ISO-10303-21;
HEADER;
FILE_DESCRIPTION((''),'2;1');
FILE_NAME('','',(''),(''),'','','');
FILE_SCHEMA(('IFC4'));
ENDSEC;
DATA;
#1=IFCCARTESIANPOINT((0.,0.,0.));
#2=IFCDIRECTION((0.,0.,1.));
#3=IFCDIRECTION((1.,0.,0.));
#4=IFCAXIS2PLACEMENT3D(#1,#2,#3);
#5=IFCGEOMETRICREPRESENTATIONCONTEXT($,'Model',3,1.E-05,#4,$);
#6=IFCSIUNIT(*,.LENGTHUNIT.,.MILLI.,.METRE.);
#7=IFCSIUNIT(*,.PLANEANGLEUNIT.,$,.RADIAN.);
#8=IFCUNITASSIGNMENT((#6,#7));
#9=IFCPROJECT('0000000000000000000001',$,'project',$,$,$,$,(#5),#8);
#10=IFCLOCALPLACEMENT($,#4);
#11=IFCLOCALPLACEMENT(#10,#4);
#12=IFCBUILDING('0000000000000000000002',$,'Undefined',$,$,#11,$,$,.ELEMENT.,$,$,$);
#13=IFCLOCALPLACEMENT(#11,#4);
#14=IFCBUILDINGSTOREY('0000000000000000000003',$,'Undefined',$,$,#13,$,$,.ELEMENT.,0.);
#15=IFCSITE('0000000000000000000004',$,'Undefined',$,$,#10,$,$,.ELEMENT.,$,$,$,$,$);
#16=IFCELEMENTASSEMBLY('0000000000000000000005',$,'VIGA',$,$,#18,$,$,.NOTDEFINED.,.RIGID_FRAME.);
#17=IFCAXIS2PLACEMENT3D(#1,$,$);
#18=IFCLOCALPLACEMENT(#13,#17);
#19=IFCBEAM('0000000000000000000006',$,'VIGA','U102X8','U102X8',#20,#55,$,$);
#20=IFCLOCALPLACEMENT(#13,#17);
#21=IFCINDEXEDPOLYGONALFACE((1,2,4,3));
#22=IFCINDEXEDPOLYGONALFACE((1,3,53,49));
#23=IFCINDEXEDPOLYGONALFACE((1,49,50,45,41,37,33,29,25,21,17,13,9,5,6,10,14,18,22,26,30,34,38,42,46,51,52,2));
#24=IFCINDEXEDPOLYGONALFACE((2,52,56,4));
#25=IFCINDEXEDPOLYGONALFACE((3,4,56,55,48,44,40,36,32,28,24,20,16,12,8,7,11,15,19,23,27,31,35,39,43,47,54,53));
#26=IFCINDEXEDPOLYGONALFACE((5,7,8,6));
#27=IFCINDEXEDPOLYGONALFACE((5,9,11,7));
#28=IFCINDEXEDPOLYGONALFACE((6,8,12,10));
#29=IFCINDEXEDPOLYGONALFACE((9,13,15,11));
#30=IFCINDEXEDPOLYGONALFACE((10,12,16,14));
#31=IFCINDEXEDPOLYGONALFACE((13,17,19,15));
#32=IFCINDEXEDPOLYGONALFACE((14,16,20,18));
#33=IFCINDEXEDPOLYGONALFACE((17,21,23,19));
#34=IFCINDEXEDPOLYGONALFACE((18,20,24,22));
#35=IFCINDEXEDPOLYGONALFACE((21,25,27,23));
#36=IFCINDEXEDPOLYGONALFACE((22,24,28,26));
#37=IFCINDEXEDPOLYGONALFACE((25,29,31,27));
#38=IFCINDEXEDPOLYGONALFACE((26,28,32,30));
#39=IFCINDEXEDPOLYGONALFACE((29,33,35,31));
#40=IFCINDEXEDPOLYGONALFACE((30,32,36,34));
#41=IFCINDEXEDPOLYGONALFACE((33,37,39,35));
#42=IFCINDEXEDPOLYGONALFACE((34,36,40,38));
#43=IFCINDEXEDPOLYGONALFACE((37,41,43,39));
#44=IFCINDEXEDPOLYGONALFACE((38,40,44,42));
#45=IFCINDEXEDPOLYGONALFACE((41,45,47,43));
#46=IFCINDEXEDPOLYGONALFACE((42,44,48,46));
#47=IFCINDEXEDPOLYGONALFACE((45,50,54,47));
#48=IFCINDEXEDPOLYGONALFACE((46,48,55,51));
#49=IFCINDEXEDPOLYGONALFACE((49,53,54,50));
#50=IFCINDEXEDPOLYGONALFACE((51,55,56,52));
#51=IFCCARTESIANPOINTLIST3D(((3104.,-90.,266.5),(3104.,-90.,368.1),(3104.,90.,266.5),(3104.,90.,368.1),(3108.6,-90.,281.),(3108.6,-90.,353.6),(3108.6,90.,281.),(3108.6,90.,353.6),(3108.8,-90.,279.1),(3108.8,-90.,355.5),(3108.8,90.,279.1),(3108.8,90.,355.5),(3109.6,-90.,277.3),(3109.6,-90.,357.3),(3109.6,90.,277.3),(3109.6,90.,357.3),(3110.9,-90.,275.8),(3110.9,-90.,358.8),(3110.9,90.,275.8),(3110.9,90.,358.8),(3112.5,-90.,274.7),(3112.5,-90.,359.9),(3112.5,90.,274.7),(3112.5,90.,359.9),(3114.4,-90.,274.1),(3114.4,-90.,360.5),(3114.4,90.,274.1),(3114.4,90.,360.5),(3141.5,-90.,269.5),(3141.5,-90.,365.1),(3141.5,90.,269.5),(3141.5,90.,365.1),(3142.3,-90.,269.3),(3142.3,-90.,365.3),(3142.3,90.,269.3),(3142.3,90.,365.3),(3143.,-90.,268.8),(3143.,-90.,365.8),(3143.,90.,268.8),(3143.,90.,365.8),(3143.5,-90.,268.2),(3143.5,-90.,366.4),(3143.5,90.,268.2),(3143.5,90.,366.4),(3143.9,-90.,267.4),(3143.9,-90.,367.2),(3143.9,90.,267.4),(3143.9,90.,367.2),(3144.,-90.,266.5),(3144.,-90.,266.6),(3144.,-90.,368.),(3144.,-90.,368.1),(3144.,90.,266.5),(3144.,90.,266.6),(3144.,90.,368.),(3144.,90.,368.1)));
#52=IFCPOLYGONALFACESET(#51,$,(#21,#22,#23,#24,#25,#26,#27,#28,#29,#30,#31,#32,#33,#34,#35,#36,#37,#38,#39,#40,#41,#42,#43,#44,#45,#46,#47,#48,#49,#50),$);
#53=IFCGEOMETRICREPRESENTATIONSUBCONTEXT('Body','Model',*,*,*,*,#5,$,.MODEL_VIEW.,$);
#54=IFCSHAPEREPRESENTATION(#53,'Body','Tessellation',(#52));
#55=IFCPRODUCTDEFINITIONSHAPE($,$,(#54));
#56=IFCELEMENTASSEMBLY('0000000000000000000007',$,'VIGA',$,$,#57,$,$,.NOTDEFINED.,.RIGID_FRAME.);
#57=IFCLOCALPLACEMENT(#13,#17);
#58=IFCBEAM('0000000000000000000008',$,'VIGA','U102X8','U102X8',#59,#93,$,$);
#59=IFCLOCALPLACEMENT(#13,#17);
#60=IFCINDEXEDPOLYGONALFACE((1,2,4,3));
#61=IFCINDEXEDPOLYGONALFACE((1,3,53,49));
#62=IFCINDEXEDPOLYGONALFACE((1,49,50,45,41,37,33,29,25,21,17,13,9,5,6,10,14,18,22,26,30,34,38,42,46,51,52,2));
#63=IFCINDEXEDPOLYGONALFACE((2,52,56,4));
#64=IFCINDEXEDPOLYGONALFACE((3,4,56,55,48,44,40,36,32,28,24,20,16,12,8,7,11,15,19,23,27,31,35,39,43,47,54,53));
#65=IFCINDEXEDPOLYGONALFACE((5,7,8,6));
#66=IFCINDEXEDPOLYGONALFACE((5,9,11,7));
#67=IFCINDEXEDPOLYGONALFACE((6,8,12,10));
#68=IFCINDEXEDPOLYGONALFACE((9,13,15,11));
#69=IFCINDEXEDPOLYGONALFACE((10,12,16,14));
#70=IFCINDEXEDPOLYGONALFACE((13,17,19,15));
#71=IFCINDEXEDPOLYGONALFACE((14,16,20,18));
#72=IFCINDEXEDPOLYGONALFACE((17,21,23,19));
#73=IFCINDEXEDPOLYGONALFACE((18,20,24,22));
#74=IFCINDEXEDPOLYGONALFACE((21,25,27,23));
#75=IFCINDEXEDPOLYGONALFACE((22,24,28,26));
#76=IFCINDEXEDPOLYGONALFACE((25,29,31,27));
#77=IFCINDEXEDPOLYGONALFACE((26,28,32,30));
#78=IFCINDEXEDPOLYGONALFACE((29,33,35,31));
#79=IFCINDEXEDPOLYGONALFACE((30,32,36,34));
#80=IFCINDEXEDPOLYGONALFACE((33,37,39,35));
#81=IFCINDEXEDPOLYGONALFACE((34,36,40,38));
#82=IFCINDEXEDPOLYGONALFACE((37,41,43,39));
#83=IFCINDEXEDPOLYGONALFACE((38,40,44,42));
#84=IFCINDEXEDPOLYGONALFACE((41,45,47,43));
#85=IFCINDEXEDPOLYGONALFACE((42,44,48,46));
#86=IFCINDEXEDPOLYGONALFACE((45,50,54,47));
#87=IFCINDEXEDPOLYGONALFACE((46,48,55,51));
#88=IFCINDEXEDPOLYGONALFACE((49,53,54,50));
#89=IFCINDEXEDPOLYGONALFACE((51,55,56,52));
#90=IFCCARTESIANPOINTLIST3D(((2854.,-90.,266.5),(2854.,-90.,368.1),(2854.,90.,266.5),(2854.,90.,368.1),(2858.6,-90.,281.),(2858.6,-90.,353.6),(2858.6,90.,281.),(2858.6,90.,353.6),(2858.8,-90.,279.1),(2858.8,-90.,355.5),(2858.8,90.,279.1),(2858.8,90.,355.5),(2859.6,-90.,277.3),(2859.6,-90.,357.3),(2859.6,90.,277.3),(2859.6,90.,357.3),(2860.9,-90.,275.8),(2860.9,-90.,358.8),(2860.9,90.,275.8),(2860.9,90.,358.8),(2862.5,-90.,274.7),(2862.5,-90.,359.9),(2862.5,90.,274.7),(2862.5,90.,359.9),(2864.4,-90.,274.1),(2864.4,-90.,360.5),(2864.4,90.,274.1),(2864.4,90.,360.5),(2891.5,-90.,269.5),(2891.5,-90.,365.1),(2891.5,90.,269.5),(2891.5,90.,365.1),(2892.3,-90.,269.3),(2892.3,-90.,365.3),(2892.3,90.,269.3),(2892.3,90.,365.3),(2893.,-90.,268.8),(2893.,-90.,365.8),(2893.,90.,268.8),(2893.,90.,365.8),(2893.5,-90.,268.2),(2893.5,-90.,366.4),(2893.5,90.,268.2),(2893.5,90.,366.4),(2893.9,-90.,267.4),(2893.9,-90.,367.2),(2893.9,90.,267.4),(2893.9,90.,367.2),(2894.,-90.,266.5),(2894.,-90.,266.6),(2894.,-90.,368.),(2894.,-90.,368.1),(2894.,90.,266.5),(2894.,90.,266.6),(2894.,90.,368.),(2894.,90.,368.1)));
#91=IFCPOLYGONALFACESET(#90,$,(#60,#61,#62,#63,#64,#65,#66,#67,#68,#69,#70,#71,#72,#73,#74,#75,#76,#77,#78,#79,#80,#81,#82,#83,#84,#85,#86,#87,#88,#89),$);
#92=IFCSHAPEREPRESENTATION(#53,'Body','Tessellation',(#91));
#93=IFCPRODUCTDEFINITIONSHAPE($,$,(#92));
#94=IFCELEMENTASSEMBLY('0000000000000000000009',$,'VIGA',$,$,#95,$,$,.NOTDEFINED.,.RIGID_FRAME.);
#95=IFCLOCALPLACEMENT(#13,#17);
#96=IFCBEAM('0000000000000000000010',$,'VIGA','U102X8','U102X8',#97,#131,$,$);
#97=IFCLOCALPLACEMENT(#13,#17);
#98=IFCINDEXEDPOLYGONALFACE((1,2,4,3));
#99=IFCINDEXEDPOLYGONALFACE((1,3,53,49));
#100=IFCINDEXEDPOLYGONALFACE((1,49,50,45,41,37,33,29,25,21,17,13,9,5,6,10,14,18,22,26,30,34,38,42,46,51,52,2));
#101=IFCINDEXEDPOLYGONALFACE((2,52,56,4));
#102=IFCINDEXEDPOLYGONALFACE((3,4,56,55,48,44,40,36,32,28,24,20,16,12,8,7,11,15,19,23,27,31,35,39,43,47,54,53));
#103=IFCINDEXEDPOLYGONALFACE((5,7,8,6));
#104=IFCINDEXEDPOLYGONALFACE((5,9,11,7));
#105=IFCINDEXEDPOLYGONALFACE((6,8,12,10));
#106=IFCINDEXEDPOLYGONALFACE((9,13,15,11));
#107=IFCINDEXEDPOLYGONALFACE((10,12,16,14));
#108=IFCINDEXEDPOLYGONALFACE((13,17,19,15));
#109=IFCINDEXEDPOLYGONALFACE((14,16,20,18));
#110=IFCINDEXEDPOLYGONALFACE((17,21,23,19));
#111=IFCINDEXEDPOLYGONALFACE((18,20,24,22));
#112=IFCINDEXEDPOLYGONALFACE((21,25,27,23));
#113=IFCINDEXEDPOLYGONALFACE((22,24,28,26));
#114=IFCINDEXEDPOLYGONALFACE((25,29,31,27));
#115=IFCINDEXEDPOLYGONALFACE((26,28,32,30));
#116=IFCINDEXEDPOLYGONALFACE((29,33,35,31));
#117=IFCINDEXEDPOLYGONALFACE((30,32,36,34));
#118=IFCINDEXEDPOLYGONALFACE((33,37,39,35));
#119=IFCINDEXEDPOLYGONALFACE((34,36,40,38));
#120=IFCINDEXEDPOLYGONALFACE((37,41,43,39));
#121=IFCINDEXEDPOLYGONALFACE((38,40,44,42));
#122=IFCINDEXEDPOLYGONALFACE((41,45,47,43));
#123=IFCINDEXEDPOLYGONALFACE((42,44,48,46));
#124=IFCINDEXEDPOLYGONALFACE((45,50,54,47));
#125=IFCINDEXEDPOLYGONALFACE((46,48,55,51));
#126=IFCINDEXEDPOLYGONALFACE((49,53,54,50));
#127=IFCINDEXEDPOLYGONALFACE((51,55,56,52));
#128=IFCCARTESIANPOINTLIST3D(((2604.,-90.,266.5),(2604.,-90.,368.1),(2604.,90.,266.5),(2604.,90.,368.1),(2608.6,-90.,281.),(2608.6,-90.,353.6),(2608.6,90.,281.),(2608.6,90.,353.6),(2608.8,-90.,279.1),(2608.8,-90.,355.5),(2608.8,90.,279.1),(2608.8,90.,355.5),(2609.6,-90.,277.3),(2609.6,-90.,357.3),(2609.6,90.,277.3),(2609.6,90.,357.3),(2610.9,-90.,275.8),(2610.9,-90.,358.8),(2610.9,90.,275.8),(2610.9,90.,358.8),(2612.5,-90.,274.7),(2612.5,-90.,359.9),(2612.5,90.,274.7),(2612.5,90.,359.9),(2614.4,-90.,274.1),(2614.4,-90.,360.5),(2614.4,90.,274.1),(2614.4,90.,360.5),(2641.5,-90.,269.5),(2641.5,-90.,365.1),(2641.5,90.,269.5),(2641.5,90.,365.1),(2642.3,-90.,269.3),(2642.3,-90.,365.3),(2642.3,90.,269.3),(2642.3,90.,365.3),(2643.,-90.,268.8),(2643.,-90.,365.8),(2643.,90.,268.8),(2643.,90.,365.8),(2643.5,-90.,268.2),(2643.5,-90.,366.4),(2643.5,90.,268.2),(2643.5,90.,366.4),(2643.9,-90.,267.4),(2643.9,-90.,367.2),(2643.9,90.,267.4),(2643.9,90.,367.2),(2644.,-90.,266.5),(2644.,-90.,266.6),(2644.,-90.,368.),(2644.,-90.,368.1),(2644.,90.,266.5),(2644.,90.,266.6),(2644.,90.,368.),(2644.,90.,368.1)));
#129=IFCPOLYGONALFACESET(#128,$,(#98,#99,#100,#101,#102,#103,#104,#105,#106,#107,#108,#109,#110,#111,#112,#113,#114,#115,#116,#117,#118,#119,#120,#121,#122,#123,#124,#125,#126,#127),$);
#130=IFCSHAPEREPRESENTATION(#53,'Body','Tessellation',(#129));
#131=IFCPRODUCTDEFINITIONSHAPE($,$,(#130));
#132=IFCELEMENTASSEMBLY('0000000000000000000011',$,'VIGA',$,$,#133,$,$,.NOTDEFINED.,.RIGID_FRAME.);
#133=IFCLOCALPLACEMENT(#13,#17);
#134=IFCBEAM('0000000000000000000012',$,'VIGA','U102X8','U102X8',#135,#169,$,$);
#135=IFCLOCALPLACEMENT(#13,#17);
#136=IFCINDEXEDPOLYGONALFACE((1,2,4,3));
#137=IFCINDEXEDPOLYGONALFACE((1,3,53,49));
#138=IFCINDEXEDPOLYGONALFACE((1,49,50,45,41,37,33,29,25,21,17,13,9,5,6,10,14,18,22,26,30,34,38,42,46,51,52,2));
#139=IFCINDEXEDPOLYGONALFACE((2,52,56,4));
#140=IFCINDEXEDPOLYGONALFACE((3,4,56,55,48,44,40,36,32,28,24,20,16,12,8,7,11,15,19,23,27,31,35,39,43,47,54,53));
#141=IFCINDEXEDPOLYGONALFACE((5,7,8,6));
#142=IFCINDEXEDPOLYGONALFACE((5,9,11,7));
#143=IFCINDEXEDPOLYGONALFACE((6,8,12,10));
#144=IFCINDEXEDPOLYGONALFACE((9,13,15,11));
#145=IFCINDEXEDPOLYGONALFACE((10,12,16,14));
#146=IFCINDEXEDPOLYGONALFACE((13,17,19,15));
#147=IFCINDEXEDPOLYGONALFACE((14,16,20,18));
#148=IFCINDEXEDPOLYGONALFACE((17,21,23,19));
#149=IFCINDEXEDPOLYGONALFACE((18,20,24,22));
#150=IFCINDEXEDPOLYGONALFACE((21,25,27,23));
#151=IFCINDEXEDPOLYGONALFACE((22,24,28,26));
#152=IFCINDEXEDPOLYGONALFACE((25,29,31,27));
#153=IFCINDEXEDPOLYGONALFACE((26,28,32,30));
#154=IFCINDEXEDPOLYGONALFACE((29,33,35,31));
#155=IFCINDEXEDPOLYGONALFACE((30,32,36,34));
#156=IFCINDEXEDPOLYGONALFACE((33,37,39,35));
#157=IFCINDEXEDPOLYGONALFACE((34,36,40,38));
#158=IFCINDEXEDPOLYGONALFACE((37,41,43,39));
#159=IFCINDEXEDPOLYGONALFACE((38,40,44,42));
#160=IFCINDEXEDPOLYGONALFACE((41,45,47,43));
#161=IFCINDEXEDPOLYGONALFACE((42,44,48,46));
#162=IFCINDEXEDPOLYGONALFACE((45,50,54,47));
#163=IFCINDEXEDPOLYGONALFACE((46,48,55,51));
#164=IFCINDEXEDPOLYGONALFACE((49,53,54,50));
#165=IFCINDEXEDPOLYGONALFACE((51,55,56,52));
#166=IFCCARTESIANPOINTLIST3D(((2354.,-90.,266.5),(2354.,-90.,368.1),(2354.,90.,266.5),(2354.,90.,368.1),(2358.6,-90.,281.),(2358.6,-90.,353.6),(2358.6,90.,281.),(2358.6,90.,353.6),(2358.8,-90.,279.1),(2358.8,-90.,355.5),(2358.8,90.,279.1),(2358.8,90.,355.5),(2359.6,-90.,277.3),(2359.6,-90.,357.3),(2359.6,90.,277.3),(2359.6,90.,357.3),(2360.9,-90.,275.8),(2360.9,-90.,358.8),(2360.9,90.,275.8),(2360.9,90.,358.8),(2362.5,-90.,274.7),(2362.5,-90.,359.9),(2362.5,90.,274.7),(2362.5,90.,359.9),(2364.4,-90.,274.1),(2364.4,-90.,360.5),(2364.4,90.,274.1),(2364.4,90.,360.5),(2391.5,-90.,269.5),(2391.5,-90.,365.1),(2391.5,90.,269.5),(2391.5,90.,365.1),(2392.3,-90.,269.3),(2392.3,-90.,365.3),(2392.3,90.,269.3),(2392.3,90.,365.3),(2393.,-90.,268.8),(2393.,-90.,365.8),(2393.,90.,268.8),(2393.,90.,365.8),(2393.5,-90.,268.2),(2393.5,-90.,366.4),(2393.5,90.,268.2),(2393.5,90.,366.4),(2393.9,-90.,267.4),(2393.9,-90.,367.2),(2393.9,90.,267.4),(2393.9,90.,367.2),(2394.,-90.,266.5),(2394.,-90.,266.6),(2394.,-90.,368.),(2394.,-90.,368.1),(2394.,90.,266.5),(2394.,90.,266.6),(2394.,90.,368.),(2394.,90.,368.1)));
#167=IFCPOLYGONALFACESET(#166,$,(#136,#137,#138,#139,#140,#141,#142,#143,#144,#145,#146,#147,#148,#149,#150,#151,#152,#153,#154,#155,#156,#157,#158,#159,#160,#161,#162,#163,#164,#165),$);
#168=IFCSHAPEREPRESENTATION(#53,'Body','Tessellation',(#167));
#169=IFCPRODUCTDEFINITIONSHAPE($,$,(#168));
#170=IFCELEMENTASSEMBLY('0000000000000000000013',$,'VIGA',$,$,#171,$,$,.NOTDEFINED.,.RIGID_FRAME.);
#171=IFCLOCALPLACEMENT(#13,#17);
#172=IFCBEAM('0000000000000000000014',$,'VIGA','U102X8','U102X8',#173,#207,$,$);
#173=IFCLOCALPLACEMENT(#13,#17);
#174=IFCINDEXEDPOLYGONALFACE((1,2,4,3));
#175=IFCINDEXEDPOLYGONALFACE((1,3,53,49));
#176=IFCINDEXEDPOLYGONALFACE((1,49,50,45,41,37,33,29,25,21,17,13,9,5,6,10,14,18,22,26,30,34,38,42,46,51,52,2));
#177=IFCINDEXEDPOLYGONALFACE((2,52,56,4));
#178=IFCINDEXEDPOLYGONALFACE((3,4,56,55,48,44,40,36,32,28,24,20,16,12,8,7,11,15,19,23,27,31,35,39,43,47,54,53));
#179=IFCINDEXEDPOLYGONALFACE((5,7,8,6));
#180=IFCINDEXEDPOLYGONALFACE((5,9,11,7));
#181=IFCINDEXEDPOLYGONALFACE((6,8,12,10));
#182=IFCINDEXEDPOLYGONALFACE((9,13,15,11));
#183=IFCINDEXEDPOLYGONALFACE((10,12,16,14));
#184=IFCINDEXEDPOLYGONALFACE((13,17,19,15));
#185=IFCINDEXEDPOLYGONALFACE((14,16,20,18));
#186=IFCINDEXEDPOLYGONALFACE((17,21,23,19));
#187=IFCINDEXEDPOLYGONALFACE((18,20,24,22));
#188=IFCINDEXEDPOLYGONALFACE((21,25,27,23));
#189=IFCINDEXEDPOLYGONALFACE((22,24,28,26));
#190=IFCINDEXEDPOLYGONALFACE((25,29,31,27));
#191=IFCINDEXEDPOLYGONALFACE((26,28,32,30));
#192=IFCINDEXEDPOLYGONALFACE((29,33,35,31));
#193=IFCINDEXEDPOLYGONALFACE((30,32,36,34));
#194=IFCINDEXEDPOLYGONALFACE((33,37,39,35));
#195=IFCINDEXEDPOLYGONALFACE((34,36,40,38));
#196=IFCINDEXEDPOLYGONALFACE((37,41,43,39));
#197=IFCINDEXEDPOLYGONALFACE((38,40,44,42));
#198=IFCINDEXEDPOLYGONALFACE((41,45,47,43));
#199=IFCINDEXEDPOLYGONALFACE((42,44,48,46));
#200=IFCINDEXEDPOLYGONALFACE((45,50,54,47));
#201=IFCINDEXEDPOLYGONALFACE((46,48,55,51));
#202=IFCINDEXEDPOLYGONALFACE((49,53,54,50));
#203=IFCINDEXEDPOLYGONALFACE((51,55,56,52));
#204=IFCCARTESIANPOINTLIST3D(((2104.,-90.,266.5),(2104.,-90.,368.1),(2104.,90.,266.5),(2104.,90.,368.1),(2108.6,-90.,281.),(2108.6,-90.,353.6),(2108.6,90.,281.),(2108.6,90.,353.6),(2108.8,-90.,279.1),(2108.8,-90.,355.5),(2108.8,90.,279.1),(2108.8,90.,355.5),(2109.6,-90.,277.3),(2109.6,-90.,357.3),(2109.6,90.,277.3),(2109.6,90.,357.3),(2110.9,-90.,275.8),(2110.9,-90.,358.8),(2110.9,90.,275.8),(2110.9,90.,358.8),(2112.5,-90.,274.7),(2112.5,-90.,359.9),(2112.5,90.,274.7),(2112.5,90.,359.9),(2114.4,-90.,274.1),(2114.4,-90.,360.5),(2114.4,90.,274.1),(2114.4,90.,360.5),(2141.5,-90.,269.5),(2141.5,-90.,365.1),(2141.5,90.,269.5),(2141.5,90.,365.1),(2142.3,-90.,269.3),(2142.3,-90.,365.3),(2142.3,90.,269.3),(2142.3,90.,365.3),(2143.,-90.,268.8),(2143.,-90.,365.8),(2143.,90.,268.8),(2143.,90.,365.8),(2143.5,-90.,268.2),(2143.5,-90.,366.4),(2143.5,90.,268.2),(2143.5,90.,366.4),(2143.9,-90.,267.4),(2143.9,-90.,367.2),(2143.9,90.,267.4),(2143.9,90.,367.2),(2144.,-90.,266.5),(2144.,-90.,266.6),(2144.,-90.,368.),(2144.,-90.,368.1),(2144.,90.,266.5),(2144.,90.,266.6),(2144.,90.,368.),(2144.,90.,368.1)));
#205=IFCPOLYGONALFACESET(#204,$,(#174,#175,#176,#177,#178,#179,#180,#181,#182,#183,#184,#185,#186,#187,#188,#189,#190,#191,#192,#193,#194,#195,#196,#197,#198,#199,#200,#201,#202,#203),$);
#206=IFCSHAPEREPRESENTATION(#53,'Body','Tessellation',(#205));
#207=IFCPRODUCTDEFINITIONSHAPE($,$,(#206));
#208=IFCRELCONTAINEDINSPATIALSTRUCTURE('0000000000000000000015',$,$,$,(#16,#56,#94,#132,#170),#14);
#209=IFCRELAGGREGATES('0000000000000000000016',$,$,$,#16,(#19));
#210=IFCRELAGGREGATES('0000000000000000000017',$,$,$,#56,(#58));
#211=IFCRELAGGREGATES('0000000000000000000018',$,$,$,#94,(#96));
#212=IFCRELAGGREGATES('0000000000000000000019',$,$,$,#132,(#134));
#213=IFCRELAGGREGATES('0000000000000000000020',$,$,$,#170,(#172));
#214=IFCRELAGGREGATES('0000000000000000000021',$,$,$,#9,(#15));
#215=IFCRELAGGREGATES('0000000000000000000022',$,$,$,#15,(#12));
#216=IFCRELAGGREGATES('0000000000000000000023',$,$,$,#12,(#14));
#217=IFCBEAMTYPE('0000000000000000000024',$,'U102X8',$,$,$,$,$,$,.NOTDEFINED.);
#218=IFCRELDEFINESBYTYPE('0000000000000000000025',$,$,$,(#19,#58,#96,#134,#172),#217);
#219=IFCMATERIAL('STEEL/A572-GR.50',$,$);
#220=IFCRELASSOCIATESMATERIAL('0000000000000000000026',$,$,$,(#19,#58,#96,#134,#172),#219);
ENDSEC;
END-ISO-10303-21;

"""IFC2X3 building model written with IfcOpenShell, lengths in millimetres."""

from ifc_helpers import new_model, si_unit, frame, origin_with_axes, origin_2d_with_axis, place, context, subcontext, project, spatial, u_section, extrude, material, type_object, element, aggregate, save


model = new_model("IFC2X3")

# Units and contexts
model_context = context("Model", 3, precision=1e-05, world=origin_with_axes())
body_context = subcontext(model_context, "Body", "Model", "MODEL_VIEW")
ifc_project = project(units=[si_unit("LENGTHUNIT", "METRE", prefix="MILLI"), si_unit("PLANEANGLEUNIT", "RADIAN")], contexts=[model_context])

# Site, building, storey
site_placement = place(None, origin_with_axes())
site = spatial("IfcSite", under=ifc_project, at=site_placement, Name="Undefined", CompositionType="ELEMENT")
building_placement = place(site_placement, origin_with_axes())
building = spatial("IfcBuilding", under=site, at=building_placement, Name="Undefined", CompositionType="ELEMENT")
storey_placement = place(building_placement, origin_with_axes())
storey = spatial("IfcBuildingStorey", under=building, at=storey_placement, Name="Undefined", CompositionType="ELEMENT", Elevation=0.0)

# Element assemblies, beams
ifc_material_1 = material(Name="STEEL/A572-GR.50")
beam_type_1 = type_object("IfcBeamType", Name="U102X8", PredefinedType="NOTDEFINED")
assembly_1_placement = place(storey_placement, origin_with_axes())
assembly_1 = element("IfcElementAssembly", 1, at=assembly_1_placement, inside=storey, Name="VIGA", AssemblyPlace="NOTDEFINED", PredefinedType="RIGID_FRAME")
beam_1_placement = place(assembly_1_placement, frame((3124.0, -90.0, 317.3), z_axis=(0.0, 0.0, 1.0), x_axis=(0.0, 1.0, 0.0)))
beam_1 = element("IfcBeam", 2, at=beam_1_placement, type_object=beam_type_1, material=ifc_material_1, Name="VIGA", Description="U102X8", ObjectType="U102X8", context=body_context, shape_type="SweptSolid", body=[
    extrude(u_section(Depth=101.6, FlangeWidth=40.0, WebThickness=4.6, FlangeThickness=6.0, FilletRadius=7.0, EdgeRadius=3.0, FlangeSlope=0.16839, at=origin_2d_with_axis()), frame((180.0, 0.0, 0.0), z_axis=(-1.0, 0.0, 0.0), x_axis=(0.0, -1.0, 0.0)), (0.0, 0.0, 1.0), 180.0),
])
aggregate(assembly_1, [beam_1])
assembly_2_placement = place(storey_placement, origin_with_axes())
assembly_2 = element("IfcElementAssembly", 3, at=assembly_2_placement, inside=storey, Name="VIGA", AssemblyPlace="NOTDEFINED", PredefinedType="RIGID_FRAME")
beam_2_placement = place(assembly_2_placement, frame((2874.0, -90.0, 317.3), z_axis=(0.0, 0.0, 1.0), x_axis=(0.0, 1.0, 0.0)))
beam_2 = element("IfcBeam", 4, at=beam_2_placement, type_object=beam_type_1, material=ifc_material_1, Name="VIGA", Description="U102X8", ObjectType="U102X8", context=body_context, shape_type="SweptSolid", body=[
    extrude(u_section(Depth=101.6, FlangeWidth=40.0, WebThickness=4.6, FlangeThickness=6.0, FilletRadius=7.0, EdgeRadius=3.0, FlangeSlope=0.16839, at=origin_2d_with_axis()), frame((180.0, 0.0, 0.0), z_axis=(-1.0, 0.0, 0.0), x_axis=(0.0, -1.0, 0.0)), (0.0, 0.0, 1.0), 180.0),
])
aggregate(assembly_2, [beam_2])
assembly_3_placement = place(storey_placement, origin_with_axes())
assembly_3 = element("IfcElementAssembly", 5, at=assembly_3_placement, inside=storey, Name="VIGA", AssemblyPlace="NOTDEFINED", PredefinedType="RIGID_FRAME")
beam_3_placement = place(assembly_3_placement, frame((2624.0, -90.0, 317.3), z_axis=(0.0, 0.0, 1.0), x_axis=(0.0, 1.0, 0.0)))
beam_3 = element("IfcBeam", 6, at=beam_3_placement, type_object=beam_type_1, material=ifc_material_1, Name="VIGA", Description="U102X8", ObjectType="U102X8", context=body_context, shape_type="SweptSolid", body=[
    extrude(u_section(Depth=101.6, FlangeWidth=40.0, WebThickness=4.6, FlangeThickness=6.0, FilletRadius=7.0, EdgeRadius=3.0, FlangeSlope=0.16839, at=origin_2d_with_axis()), frame((180.0, 0.0, 0.0), z_axis=(-1.0, 0.0, 0.0), x_axis=(0.0, -1.0, 0.0)), (0.0, 0.0, 1.0), 180.0),
])
aggregate(assembly_3, [beam_3])
assembly_4_placement = place(storey_placement, origin_with_axes())
assembly_4 = element("IfcElementAssembly", 7, at=assembly_4_placement, inside=storey, Name="VIGA", AssemblyPlace="NOTDEFINED", PredefinedType="RIGID_FRAME")
beam_4_placement = place(assembly_4_placement, frame((2374.0, -90.0, 317.3), z_axis=(0.0, 0.0, 1.0), x_axis=(0.0, 1.0, 0.0)))
beam_4 = element("IfcBeam", 8, at=beam_4_placement, type_object=beam_type_1, material=ifc_material_1, Name="VIGA", Description="U102X8", ObjectType="U102X8", context=body_context, shape_type="SweptSolid", body=[
    extrude(u_section(Depth=101.6, FlangeWidth=40.0, WebThickness=4.6, FlangeThickness=6.0, FilletRadius=7.0, EdgeRadius=3.0, FlangeSlope=0.16839, at=origin_2d_with_axis()), frame((180.0, 0.0, 0.0), z_axis=(-1.0, 0.0, 0.0), x_axis=(0.0, -1.0, 0.0)), (0.0, 0.0, 1.0), 180.0),
])
aggregate(assembly_4, [beam_4])
assembly_5_placement = place(storey_placement, origin_with_axes())
assembly_5 = element("IfcElementAssembly", 9, at=assembly_5_placement, inside=storey, Name="VIGA", AssemblyPlace="NOTDEFINED", PredefinedType="RIGID_FRAME")
beam_5_placement = place(assembly_5_placement, frame((2124.0, -90.0, 317.3), z_axis=(0.0, 0.0, 1.0), x_axis=(0.0, 1.0, 0.0)))
beam_5 = element("IfcBeam", 10, at=beam_5_placement, type_object=beam_type_1, material=ifc_material_1, Name="VIGA", Description="U102X8", ObjectType="U102X8", context=body_context, shape_type="SweptSolid", body=[
    extrude(u_section(Depth=101.6, FlangeWidth=40.0, WebThickness=4.6, FlangeThickness=6.0, FilletRadius=7.0, EdgeRadius=3.0, FlangeSlope=0.16839, at=origin_2d_with_axis()), frame((180.0, 0.0, 0.0), z_axis=(-1.0, 0.0, 0.0), x_axis=(0.0, -1.0, 0.0)), (0.0, 0.0, 1.0), 180.0),
])
aggregate(assembly_5, [beam_5])

save(model, "model.ifc")
